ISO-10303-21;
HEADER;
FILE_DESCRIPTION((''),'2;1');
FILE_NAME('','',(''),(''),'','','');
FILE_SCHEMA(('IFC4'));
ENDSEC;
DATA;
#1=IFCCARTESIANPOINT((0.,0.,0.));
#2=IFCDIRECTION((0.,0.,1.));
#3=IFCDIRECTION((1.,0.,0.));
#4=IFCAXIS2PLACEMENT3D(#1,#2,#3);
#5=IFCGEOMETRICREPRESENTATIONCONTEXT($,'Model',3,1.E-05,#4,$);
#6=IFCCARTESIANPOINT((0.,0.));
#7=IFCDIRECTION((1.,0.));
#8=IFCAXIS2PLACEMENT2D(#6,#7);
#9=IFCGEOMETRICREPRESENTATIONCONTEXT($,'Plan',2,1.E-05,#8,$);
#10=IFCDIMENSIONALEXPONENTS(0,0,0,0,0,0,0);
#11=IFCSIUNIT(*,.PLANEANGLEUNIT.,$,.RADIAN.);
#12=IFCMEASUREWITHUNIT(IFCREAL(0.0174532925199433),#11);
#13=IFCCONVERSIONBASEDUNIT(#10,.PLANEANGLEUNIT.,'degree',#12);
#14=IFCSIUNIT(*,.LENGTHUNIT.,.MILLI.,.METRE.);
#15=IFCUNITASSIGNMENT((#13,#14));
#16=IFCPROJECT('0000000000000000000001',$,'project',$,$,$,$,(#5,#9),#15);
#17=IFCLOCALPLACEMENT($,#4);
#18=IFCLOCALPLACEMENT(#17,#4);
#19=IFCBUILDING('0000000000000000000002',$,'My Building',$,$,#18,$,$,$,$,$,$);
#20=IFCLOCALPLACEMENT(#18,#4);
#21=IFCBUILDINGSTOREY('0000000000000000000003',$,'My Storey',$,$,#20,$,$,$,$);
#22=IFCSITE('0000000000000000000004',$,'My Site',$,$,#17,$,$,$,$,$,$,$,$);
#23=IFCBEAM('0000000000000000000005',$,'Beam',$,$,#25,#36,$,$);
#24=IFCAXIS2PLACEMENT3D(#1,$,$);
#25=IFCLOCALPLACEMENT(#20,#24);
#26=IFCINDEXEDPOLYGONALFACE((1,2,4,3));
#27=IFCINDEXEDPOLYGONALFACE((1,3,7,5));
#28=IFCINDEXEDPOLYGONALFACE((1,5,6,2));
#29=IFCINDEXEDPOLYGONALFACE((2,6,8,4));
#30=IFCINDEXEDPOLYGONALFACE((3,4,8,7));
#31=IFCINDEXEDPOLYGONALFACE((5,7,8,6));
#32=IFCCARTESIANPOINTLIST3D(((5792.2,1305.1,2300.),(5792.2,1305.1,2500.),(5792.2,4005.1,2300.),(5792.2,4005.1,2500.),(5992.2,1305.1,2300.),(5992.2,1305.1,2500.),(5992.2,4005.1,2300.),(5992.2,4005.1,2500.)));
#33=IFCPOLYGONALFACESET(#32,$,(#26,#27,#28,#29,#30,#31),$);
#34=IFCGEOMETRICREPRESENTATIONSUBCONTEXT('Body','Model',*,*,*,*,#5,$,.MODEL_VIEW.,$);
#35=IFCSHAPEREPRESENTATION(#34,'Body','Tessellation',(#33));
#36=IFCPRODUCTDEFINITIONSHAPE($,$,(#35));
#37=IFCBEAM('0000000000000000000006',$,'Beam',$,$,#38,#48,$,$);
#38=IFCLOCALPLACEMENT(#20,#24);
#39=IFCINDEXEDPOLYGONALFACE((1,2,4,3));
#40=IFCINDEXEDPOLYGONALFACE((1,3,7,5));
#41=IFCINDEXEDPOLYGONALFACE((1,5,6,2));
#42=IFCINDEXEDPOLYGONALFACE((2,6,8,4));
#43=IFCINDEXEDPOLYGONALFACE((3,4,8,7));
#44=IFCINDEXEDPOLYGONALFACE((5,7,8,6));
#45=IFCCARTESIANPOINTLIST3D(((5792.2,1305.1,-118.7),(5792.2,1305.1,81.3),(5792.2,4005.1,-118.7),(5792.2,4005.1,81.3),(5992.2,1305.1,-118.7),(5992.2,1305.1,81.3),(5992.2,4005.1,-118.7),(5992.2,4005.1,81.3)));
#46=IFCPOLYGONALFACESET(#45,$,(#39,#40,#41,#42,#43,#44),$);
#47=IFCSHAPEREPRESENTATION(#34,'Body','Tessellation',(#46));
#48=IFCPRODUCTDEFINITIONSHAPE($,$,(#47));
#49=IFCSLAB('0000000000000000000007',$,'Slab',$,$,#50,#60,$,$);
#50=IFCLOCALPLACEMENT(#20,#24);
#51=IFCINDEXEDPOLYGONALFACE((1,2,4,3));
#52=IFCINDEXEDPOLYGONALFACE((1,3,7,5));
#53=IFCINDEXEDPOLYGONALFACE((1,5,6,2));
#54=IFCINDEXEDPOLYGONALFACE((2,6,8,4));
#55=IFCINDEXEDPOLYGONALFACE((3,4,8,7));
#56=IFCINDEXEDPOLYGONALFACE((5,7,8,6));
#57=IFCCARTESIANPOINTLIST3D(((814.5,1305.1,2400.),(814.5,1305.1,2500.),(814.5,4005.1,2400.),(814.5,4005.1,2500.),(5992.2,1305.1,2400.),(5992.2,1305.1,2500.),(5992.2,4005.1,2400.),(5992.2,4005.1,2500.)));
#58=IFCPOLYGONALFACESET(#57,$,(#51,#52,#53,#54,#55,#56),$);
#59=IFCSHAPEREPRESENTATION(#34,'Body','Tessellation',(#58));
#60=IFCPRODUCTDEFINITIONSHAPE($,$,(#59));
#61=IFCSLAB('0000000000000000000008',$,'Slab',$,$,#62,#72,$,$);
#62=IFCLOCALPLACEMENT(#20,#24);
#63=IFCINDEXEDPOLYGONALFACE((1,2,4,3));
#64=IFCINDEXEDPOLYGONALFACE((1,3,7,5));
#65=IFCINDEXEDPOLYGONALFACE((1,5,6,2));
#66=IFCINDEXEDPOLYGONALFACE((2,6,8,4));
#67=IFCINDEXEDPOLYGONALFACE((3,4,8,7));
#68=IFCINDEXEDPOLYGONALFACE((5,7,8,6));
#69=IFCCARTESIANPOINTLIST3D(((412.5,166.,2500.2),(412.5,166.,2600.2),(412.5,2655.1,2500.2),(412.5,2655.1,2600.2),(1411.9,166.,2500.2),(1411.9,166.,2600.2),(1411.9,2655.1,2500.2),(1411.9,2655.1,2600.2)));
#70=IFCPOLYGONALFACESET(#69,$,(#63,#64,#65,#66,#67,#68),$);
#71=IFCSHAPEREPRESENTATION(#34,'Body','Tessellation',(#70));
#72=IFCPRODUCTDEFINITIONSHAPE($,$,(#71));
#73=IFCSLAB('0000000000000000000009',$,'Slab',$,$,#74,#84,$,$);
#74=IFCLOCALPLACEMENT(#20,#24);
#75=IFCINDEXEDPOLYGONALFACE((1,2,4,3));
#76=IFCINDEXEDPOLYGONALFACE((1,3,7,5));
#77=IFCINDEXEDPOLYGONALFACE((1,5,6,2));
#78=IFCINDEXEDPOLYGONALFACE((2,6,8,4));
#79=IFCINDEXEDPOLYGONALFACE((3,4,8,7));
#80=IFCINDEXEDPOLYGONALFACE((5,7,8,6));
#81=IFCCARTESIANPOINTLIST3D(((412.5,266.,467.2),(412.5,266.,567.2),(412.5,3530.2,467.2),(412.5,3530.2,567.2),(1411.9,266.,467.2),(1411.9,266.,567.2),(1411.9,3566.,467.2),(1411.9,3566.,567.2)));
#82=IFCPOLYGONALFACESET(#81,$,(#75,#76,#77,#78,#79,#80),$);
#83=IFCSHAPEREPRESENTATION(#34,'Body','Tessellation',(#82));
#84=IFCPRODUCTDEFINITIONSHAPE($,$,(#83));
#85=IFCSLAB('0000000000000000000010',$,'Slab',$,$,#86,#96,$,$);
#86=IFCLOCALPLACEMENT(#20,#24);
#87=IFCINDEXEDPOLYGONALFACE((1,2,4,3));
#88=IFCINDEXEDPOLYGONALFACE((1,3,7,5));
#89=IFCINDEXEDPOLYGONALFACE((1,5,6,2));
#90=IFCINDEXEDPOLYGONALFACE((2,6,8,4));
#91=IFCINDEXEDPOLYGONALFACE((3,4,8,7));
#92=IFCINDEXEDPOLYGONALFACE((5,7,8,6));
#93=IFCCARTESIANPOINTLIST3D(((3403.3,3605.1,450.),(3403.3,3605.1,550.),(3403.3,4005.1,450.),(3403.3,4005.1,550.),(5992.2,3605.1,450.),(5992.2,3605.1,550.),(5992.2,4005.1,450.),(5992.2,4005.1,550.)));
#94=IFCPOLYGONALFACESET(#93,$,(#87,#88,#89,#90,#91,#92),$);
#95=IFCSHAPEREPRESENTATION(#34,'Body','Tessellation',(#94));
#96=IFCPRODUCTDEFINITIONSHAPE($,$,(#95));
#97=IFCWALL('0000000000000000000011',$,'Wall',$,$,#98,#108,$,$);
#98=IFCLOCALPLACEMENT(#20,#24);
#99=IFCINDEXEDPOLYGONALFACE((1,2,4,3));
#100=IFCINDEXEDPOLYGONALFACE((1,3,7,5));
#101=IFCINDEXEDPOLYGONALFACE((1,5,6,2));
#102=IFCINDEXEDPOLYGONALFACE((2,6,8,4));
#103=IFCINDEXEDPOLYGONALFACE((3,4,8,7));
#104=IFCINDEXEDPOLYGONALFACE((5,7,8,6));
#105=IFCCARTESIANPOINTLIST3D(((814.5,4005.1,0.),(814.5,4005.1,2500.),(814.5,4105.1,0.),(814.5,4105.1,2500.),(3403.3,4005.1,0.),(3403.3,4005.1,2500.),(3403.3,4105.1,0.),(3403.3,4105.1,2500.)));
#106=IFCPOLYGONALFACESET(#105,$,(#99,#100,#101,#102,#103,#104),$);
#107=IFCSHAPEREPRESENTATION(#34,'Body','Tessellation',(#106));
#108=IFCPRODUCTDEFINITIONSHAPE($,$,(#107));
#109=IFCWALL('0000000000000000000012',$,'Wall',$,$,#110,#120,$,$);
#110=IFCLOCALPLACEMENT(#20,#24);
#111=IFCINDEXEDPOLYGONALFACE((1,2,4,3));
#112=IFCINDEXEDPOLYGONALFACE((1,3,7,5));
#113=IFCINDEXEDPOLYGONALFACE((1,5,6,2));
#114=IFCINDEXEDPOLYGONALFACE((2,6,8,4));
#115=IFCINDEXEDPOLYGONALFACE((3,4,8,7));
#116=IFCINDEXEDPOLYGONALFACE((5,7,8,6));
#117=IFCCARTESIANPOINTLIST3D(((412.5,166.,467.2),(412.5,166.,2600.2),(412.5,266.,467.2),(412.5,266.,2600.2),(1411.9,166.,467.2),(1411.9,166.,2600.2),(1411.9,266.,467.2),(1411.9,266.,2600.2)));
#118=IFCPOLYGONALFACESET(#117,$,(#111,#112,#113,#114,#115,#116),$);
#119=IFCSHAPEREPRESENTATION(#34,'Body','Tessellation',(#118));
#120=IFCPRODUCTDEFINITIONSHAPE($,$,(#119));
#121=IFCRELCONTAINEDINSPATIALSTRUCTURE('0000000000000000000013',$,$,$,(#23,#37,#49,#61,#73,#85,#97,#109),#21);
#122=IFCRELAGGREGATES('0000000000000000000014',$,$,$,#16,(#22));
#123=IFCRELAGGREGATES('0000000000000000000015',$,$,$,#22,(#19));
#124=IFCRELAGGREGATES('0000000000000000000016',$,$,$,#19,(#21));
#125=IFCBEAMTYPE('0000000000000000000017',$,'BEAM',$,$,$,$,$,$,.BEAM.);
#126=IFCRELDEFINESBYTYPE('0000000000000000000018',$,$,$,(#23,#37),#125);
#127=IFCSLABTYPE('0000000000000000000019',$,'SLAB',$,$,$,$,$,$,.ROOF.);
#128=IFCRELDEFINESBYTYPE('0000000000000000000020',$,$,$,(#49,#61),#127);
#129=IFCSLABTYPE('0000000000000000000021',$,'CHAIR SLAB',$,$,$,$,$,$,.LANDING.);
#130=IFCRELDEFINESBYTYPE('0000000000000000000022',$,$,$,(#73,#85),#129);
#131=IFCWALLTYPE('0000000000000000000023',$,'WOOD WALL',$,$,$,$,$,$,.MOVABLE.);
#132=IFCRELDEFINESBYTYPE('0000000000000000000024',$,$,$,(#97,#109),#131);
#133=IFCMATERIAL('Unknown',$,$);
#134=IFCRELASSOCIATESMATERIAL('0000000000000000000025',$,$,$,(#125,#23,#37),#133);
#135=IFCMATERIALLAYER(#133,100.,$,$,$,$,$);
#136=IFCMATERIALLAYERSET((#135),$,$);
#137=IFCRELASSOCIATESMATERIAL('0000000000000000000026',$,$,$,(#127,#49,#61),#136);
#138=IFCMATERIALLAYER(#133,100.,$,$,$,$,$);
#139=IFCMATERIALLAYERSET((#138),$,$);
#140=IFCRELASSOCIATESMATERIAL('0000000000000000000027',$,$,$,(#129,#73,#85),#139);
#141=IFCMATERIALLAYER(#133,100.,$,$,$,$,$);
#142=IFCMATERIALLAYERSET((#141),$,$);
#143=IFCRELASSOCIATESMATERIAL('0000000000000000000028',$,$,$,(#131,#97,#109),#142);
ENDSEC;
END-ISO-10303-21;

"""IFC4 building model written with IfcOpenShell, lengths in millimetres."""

from ifc_helpers import new_model, entity, si_unit, converted_unit, frame, origin_with_axes, origin_2d_with_axis, place, context, subcontext, project, spatial, line, indexed_curve, rectangle, outline, extrude, material, layer, layer_set, layer_usage, material_profile, profile_set, profile_usage, type_object, element, save


model = new_model("IFC4")

# Units and contexts
model_context = context("Model", 3, precision=1e-05, world=origin_with_axes())
plan_context = context("Plan", 2, precision=1e-05, world=origin_2d_with_axis())
body_context = subcontext(model_context, "Body", "Model", "MODEL_VIEW")
ifc_project = project(units=[converted_unit("PLANEANGLEUNIT", "degree", entity("IfcReal", 0.0174532925199433), si_unit("PLANEANGLEUNIT", "RADIAN"), dimensions=[0, 0, 0, 0, 0, 0, 0]), si_unit("LENGTHUNIT", "METRE", prefix="MILLI")], contexts=[model_context, plan_context])

# Site, building, storey
site_placement = place(None, origin_with_axes())
site = spatial("IfcSite", under=ifc_project, at=site_placement, Name="My Site")
building_placement = place(site_placement, origin_with_axes())
building = spatial("IfcBuilding", under=site, at=building_placement, Name="My Building")
storey_placement = place(building_placement, origin_with_axes())
storey = spatial("IfcBuildingStorey", under=building, at=storey_placement, Name="My Storey")

# Beams
ifc_material = material(Name="Unknown")
ifc_material_profile = material_profile(ifc_material, rectangle(XDim=200.0, YDim=200.0))
ifc_profile_set = profile_set([ifc_material_profile])
ifc_profile_usage_1 = profile_usage(ifc_profile_set, cardinal=5)
beam_type = type_object("IfcBeamType", Name="BEAM", PredefinedType="BEAM", material=ifc_profile_set)
beam_1_placement = place(storey_placement, frame((5892.2, 1305.1, 2400.0), z_axis=(0.0, 1.0, 0.0), x_axis=(-1.0, 0.0, 0.0)))
element("IfcBeam", 1, at=beam_1_placement, inside=storey, type_object=beam_type, material=ifc_profile_usage_1, Name="Beam", context=body_context, shape_type="SweptSolid", body=[
    extrude(rectangle(XDim=200.0, YDim=200.0), origin_with_axes(), (0.0, 0.0, 1.0), 2700.0),
])
ifc_profile_usage_2 = profile_usage(ifc_profile_set, cardinal=5)
beam_2_placement = place(storey_placement, frame((5892.2, 1305.1, -18.7), z_axis=(0.0, 1.0, 0.0), x_axis=(-1.0, 0.0, 0.0)))
element("IfcBeam", 2, at=beam_2_placement, inside=storey, type_object=beam_type, material=ifc_profile_usage_2, Name="Beam", context=body_context, shape_type="SweptSolid", body=[
    extrude(rectangle(XDim=200.0, YDim=200.0), origin_with_axes(), (0.0, 0.0, 1.0), 2700.0),
])

# Slabs
ifc_layer_1 = layer(ifc_material, 100.0)
ifc_layer_set_1 = layer_set([ifc_layer_1])
ifc_layer_usage_1 = layer_usage(ifc_layer_set_1, "AXIS3", "POSITIVE", -100.0)
slab_type_1 = type_object("IfcSlabType", Name="SLAB", PredefinedType="ROOF", material=ifc_layer_set_1)
slab_1_placement = place(storey_placement, frame((814.5, 1305.1, 2500.0), z_axis=(0.0, 0.0, 1.0), x_axis=(1.0, 0.0, 0.0)))
element("IfcSlab", 3, at=slab_1_placement, inside=storey, type_object=slab_type_1, material=ifc_layer_usage_1, Name="Slab", context=body_context, shape_type="SweptSolid", body=[
    extrude(outline(indexed_curve([(0.0, 0.0), (5177.7, 0.0), (5177.7, 2700.0), (0.0, 2700.0), (0.0, 0.0)])), frame((0.0, 0.0, -100.0), z_axis=(0.0, 0.0, 1.0), x_axis=(1.0, 0.0, 0.0)), (0.0, 0.0, 1.0), 100.0),
])
ifc_layer_usage_2 = layer_usage(ifc_layer_set_1, "AXIS3", "POSITIVE", -100.0)
slab_2_placement = place(storey_placement, frame((1411.9, 166.0, 2600.2), z_axis=(0.0, 0.0, 1.0), x_axis=(1.0, 0.0, 0.0)))
element("IfcSlab", 4, at=slab_2_placement, inside=storey, type_object=slab_type_1, material=ifc_layer_usage_2, Name="Slab", context=body_context, shape_type="SweptSolid", body=[
    extrude(outline(indexed_curve([(0.0, 0.0), (0.0, 2489.1), (-999.3, 2489.1), (-999.3, 0.0), (0.0, 0.0)])), frame((0.0, 0.0, -100.0), z_axis=(0.0, 0.0, 1.0), x_axis=(1.0, 0.0, 0.0)), (0.0, 0.0, 1.0), 100.0),
])
ifc_layer_2 = layer(ifc_material, 100.0)
ifc_layer_set_2 = layer_set([ifc_layer_2])
ifc_layer_usage_3 = layer_usage(ifc_layer_set_2, "AXIS3", "POSITIVE", -100.0)
slab_type_2 = type_object("IfcSlabType", Name="CHAIR SLAB", PredefinedType="LANDING", material=ifc_layer_set_2)
slab_3_placement = place(storey_placement, frame((412.5, 3530.2, 567.2), z_axis=(0.0, 0.0, 1.0), x_axis=(1.0, 0.0, 0.0)))
element("IfcSlab", 5, at=slab_3_placement, inside=storey, type_object=slab_type_2, material=ifc_layer_usage_3, Name="Slab", context=body_context, shape_type="SweptSolid", body=[
    extrude(outline(indexed_curve([(0.0, 0.0), (999.4, 35.8), (999.4, -3264.2), (0.0, -3264.2), (0.0, 0.0)])), frame((0.0, 0.0, -100.0), z_axis=(0.0, 0.0, 1.0), x_axis=(1.0, 0.0, 0.0)), (0.0, 0.0, 1.0), 100.0),
])
ifc_layer_usage_4 = layer_usage(ifc_layer_set_2, "AXIS3", "POSITIVE", -100.0)
slab_4_placement = place(storey_placement, frame((3403.3, 4005.1, 550.0), z_axis=(0.0, 0.0, 1.0), x_axis=(1.0, 0.0, 0.0)))
element("IfcSlab", 6, at=slab_4_placement, inside=storey, type_object=slab_type_2, material=ifc_layer_usage_4, Name="Slab", context=body_context, shape_type="SweptSolid", body=[
    extrude(outline(indexed_curve([(0.0, 0.0), (0.0, -400.0), (2588.8, -400.0), (2588.8, 0.0), (0.0, 0.0)])), frame((0.0, 0.0, -100.0), z_axis=(0.0, 0.0, 1.0), x_axis=(1.0, 0.0, 0.0)), (0.0, 0.0, 1.0), 100.0),
])

# Walls
ifc_layer_3 = layer(ifc_material, 100.0)
ifc_layer_set_3 = layer_set([ifc_layer_3])
ifc_layer_usage_5 = layer_usage(ifc_layer_set_3, "AXIS2", "POSITIVE", 0.0)
wall_type = type_object("IfcWallType", Name="WOOD WALL", PredefinedType="MOVABLE", material=ifc_layer_set_3)
wall_1_placement = place(storey_placement, frame((814.5, 4005.1, 0.0), z_axis=(0.0, 0.0, 1.0), x_axis=(1.0, 0.0, 0.0)))
element("IfcWall", 7, at=wall_1_placement, inside=storey, type_object=wall_type, material=ifc_layer_usage_5, Name="Wall", context=body_context, shape_type="SweptSolid", body=[
    extrude(outline(indexed_curve([(0.0, 0.0), (0.0, 100.0), (2588.8, 100.0), (2588.8, 0.0)], segments=[line(1, 2, 3, 4, 1)])), origin_with_axes(), (0.0, 0.0, 1.0), 2500.0),
])
ifc_layer_usage_6 = layer_usage(ifc_layer_set_3, "AXIS2", "POSITIVE", 0.0)
wall_2_placement = place(storey_placement, frame((1411.9, 266.0, 467.2), z_axis=(0.0, 0.0, 1.0), x_axis=(-1.0, 0.0, 0.0)))
element("IfcWall", 8, at=wall_2_placement, inside=storey, type_object=wall_type, material=ifc_layer_usage_6, Name="Wall", context=body_context, shape_type="SweptSolid", body=[
    extrude(outline(indexed_curve([(0.0, 0.0), (0.0, 100.0), (999.3, 100.0), (999.3, 0.0)], segments=[line(1, 2, 3, 4, 1)])), origin_with_axes(), (0.0, 0.0, 1.0), 2133.0),
])

save(model, "model.ifc")
